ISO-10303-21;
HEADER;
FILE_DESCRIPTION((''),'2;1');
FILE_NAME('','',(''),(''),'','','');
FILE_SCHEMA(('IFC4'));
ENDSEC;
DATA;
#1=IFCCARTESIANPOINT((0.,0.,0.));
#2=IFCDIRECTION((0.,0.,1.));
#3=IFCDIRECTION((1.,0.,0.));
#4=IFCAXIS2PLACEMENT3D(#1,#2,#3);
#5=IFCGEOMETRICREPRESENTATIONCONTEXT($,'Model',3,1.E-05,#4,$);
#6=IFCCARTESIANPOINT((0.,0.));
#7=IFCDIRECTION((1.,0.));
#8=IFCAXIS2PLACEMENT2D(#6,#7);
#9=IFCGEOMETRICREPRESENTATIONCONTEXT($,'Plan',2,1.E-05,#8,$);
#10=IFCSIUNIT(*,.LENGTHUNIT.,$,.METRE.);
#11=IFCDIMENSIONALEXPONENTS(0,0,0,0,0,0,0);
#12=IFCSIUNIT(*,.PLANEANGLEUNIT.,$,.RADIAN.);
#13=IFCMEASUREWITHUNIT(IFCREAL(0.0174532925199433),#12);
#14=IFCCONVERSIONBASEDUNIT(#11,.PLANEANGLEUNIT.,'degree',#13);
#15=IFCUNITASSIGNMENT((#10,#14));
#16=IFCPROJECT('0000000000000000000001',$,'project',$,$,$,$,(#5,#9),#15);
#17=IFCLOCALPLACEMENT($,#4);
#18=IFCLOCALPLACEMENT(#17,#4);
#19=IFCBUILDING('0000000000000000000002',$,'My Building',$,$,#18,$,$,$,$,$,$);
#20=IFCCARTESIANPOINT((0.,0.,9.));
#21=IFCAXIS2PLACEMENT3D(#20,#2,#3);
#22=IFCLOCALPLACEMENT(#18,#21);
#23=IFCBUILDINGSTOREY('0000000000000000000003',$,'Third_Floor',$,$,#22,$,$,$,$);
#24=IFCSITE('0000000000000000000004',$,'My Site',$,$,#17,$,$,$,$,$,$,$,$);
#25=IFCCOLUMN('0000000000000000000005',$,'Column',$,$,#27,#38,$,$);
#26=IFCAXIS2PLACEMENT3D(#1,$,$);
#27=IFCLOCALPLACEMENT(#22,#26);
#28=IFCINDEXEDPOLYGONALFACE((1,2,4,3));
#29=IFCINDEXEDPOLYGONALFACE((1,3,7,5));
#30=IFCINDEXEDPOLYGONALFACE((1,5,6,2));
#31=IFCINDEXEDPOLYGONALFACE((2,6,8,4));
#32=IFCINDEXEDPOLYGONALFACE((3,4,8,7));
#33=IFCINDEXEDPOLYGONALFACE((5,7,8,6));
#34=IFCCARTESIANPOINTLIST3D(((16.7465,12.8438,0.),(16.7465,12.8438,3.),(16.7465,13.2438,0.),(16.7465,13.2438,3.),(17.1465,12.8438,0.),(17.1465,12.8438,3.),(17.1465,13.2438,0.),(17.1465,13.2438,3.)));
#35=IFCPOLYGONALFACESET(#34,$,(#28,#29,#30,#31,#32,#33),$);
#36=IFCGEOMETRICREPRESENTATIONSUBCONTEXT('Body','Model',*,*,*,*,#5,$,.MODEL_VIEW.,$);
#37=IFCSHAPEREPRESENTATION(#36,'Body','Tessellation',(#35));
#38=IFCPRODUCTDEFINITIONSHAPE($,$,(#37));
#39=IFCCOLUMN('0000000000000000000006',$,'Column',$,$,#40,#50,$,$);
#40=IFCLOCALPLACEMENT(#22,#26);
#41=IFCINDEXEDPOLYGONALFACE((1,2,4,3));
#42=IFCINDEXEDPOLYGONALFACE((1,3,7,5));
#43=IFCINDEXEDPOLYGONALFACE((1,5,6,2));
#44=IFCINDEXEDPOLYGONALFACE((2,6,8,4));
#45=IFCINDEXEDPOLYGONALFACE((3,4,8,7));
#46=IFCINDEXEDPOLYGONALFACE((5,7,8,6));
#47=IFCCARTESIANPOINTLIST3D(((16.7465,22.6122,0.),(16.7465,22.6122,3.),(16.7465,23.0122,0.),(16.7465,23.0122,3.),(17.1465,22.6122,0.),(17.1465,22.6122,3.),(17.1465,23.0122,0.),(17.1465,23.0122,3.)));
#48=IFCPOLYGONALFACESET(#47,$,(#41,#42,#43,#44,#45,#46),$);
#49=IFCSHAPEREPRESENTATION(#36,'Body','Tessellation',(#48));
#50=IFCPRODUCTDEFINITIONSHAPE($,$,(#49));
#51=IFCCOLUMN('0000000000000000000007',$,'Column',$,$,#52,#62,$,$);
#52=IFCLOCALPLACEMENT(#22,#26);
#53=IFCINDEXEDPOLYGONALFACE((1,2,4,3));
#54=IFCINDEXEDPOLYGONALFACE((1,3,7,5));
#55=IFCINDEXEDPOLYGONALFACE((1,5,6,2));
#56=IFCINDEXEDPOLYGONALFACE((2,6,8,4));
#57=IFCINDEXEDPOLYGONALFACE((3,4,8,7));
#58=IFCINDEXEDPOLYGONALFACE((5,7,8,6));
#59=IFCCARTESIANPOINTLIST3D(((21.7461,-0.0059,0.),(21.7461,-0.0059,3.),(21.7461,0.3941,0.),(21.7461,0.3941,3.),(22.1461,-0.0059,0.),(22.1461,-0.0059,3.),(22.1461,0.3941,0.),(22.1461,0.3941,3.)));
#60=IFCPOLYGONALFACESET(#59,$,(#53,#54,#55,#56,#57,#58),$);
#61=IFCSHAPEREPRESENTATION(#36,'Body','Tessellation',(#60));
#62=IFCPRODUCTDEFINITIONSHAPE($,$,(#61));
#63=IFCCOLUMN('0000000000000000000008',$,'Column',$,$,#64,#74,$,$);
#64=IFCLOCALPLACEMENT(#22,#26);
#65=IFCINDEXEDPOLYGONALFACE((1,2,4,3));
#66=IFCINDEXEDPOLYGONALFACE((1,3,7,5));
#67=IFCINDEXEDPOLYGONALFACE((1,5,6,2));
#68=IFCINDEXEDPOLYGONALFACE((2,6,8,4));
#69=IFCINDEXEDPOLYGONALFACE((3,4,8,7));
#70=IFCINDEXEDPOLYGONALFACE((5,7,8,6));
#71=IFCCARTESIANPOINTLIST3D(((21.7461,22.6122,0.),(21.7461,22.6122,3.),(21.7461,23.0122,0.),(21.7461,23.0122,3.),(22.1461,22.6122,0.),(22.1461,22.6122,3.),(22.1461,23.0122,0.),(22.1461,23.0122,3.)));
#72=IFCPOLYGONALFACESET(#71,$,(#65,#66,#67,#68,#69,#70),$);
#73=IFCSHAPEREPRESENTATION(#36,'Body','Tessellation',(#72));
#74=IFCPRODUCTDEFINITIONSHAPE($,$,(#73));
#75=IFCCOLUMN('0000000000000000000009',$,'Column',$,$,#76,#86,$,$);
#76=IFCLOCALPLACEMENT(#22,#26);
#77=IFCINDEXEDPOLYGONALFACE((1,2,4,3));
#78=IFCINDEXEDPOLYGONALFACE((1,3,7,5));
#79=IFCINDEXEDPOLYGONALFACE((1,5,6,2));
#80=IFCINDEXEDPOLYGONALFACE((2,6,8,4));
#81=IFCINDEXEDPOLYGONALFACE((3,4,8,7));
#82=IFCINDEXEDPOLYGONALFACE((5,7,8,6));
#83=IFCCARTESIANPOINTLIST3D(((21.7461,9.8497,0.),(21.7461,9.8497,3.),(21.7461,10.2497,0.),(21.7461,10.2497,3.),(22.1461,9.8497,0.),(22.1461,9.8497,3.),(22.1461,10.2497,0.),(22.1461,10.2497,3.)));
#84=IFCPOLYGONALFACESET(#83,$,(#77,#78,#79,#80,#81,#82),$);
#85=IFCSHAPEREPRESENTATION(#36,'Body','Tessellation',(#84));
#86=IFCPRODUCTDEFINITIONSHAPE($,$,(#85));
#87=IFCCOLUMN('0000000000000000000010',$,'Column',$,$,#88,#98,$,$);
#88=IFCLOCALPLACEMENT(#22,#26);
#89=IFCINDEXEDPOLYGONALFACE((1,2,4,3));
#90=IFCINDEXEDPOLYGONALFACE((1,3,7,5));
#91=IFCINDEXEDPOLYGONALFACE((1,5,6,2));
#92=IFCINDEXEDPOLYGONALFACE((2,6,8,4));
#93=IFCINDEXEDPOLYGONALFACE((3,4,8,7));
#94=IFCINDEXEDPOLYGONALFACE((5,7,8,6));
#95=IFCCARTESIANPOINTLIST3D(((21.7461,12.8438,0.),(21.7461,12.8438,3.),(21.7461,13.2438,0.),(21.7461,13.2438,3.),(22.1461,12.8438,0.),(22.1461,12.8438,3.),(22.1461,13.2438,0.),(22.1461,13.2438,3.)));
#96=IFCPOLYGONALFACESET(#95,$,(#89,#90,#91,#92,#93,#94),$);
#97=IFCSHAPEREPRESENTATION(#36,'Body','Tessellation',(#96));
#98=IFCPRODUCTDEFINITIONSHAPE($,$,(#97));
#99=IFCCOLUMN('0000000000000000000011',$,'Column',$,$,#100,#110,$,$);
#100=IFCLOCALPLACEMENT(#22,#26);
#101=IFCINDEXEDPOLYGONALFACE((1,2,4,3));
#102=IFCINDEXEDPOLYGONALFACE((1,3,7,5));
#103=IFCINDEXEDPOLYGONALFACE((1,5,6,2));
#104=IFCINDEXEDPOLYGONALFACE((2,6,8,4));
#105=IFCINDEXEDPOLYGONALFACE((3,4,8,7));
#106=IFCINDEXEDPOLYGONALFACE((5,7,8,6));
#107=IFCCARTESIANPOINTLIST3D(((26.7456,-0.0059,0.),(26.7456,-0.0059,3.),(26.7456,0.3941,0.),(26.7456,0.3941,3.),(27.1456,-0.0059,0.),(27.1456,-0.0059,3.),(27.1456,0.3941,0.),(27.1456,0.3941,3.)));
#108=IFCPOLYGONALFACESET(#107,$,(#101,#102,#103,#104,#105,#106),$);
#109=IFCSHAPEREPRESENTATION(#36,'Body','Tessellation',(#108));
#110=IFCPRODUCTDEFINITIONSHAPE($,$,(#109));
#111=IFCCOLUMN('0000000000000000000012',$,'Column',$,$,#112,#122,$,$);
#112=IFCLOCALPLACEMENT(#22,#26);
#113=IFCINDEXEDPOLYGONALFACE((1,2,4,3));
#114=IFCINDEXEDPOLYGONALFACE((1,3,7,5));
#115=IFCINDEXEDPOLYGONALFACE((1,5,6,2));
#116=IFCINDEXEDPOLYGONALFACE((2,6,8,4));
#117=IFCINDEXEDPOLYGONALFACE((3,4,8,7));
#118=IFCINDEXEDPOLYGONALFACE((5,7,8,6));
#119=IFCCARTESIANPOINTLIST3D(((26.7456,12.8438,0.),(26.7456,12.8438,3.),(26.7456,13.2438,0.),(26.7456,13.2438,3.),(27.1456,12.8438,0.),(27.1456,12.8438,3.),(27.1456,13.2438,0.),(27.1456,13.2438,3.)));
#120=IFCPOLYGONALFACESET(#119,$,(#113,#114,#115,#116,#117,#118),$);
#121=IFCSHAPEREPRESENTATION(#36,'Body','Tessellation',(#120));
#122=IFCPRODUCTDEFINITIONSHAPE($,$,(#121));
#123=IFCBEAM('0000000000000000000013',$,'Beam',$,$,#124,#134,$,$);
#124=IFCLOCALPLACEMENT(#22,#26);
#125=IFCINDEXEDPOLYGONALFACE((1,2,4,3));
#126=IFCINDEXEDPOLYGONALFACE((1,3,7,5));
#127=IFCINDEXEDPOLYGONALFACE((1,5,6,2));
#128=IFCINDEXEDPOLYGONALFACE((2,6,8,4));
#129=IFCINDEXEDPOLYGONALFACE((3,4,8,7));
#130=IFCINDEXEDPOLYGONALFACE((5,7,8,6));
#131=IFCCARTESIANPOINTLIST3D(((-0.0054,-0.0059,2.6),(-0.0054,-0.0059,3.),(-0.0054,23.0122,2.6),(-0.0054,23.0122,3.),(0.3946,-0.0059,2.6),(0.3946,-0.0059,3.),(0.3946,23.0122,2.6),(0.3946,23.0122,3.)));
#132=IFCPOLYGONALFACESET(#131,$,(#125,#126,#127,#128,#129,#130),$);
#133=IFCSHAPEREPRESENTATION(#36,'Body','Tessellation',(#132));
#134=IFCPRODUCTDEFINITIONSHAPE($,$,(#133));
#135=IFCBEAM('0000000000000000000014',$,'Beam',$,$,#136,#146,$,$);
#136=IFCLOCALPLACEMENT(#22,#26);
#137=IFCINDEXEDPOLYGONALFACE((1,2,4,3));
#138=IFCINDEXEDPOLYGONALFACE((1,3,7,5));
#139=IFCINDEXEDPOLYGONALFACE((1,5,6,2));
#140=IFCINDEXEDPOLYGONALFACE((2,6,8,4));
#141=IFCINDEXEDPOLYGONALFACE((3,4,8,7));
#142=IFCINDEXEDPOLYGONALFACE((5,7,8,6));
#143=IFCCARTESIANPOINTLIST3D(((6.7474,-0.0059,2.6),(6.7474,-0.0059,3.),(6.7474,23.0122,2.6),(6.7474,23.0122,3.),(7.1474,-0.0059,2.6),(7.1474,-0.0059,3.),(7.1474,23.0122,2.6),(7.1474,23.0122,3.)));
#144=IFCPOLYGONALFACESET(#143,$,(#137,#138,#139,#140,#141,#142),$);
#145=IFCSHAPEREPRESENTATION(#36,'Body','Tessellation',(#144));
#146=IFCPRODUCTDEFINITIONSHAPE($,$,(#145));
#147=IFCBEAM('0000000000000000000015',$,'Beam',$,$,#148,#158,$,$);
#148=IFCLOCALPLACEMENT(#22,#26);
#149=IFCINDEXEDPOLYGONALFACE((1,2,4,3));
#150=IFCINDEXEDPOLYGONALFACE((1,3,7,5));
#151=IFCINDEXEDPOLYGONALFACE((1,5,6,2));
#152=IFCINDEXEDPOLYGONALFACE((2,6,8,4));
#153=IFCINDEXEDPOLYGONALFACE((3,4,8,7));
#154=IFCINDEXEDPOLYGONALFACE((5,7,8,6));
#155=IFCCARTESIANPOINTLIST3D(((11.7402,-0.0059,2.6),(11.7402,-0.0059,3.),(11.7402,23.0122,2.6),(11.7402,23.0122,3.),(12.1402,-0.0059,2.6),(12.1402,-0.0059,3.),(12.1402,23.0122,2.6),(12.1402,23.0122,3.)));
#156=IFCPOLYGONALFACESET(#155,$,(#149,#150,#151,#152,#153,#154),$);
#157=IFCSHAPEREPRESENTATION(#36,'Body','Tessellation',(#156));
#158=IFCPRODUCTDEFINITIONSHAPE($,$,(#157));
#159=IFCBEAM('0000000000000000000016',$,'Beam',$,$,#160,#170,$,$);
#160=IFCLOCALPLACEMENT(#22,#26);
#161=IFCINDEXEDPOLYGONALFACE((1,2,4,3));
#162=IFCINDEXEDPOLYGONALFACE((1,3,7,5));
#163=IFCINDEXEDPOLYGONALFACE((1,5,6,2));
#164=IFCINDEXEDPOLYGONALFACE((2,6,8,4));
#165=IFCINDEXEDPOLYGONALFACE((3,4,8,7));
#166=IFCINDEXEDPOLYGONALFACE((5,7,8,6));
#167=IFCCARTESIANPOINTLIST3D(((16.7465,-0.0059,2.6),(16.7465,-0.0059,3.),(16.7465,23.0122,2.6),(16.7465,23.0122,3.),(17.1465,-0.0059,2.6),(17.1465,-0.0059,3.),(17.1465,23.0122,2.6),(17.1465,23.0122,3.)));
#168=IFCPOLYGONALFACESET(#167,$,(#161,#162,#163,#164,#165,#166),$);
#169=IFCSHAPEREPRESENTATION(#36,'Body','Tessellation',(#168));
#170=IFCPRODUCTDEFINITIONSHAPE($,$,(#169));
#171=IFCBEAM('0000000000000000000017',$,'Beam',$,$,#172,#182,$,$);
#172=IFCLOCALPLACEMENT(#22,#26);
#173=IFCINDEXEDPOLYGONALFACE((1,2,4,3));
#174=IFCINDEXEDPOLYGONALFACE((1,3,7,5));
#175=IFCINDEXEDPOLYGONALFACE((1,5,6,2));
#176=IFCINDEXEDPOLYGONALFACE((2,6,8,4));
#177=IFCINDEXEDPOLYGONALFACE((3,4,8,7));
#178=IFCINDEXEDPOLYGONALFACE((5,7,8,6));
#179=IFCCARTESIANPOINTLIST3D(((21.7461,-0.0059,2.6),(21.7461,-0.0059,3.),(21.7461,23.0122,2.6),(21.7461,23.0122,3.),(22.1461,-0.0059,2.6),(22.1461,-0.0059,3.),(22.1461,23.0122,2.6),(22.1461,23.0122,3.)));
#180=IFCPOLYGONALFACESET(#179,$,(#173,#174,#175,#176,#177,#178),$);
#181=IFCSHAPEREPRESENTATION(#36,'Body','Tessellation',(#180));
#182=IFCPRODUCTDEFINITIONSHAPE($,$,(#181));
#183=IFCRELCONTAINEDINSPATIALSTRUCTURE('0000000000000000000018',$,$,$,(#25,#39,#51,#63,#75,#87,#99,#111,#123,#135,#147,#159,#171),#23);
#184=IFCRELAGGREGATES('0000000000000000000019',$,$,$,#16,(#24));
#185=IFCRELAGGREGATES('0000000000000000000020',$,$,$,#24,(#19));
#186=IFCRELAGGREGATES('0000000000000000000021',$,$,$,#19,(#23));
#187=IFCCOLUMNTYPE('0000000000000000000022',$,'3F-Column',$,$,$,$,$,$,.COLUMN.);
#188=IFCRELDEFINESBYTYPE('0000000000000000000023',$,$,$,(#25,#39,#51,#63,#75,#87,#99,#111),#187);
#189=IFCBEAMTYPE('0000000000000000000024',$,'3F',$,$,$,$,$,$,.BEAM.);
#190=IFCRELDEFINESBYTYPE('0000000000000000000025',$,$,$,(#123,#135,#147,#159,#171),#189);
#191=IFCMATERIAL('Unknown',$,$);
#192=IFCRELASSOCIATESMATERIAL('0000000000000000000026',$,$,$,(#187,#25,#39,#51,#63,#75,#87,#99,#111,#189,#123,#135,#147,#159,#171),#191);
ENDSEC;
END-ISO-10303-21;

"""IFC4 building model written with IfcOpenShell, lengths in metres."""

from ifc_helpers import new_model, entity, si_unit, converted_unit, frame, origin_with_axes, origin_2d_with_axis, place, context, subcontext, project, spatial, rectangle, extrude, material, material_profile, profile_set, profile_usage, type_object, element, save


model = new_model("IFC4")

# Units and contexts
model_context = context("Model", 3, precision=1e-05, world=origin_with_axes())
plan_context = context("Plan", 2, precision=1e-05, world=origin_2d_with_axis())
body_context = subcontext(model_context, "Body", "Model", "MODEL_VIEW")
ifc_project = project(units=[si_unit("LENGTHUNIT", "METRE"), converted_unit("PLANEANGLEUNIT", "degree", entity("IfcReal", 0.0174532925199433), si_unit("PLANEANGLEUNIT", "RADIAN"), dimensions=[0, 0, 0, 0, 0, 0, 0])], contexts=[model_context, plan_context])

# Site, building, storey
site_placement = place(None, origin_with_axes())
site = spatial("IfcSite", under=ifc_project, at=site_placement, Name="My Site")
building_placement = place(site_placement, origin_with_axes())
building = spatial("IfcBuilding", under=site, at=building_placement, Name="My Building")
storey_placement = place(building_placement, frame((0.0, 0.0, 9.0), z_axis=(0.0, 0.0, 1.0), x_axis=(1.0, 0.0, 0.0)))
storey = spatial("IfcBuildingStorey", under=building, at=storey_placement, Name="Third_Floor")

# Columns
ifc_material = material(Name="Unknown")
ifc_material_profile_1 = material_profile(ifc_material, rectangle(XDim=0.4, YDim=0.4))
ifc_profile_set_1 = profile_set([ifc_material_profile_1])
column_type = type_object("IfcColumnType", Name="3F-Column", PredefinedType="COLUMN", material=ifc_profile_set_1)
ifc_profile_usage_1 = profile_usage(ifc_profile_set_1, cardinal=8)
column_1_placement = place(storey_placement, frame((16.9465, 13.2438, 0.0), z_axis=(0.0, 0.0, 1.0), x_axis=(1.0, 0.0, 0.0)))
element("IfcColumn", 1, at=column_1_placement, inside=storey, type_object=column_type, material=ifc_profile_usage_1, Name="Column", context=body_context, shape_type="SweptSolid", body=[
    extrude(rectangle(XDim=0.4, YDim=0.4), frame((0.0, -0.2, 0.0), z_axis=(0.0, 0.0, 1.0), x_axis=(1.0, 0.0, 0.0)), (0.0, 0.0, 1.0), 3.0),
])
ifc_profile_usage_2 = profile_usage(ifc_profile_set_1, cardinal=8)
column_2_placement = place(storey_placement, frame((16.9465, 23.0122, 0.0), z_axis=(0.0, 0.0, 1.0), x_axis=(1.0, 0.0, 0.0)))
element("IfcColumn", 2, at=column_2_placement, inside=storey, type_object=column_type, material=ifc_profile_usage_2, Name="Column", context=body_context, shape_type="SweptSolid", body=[
    extrude(rectangle(XDim=0.4, YDim=0.4), frame((0.0, -0.2, 0.0), z_axis=(0.0, 0.0, 1.0), x_axis=(1.0, 0.0, 0.0)), (0.0, 0.0, 1.0), 3.0),
])
ifc_profile_usage_3 = profile_usage(ifc_profile_set_1, cardinal=8)
column_3_placement = place(storey_placement, frame((21.9461, 0.3941, 0.0), z_axis=(0.0, 0.0, 1.0), x_axis=(1.0, 0.0, 0.0)))
element("IfcColumn", 3, at=column_3_placement, inside=storey, type_object=column_type, material=ifc_profile_usage_3, Name="Column", context=body_context, shape_type="SweptSolid", body=[
    extrude(rectangle(XDim=0.4, YDim=0.4), frame((0.0, -0.2, 0.0), z_axis=(0.0, 0.0, 1.0), x_axis=(1.0, 0.0, 0.0)), (0.0, 0.0, 1.0), 3.0),
])
ifc_profile_usage_4 = profile_usage(ifc_profile_set_1, cardinal=8)
column_4_placement = place(storey_placement, frame((21.9461, 23.0122, 0.0), z_axis=(0.0, 0.0, 1.0), x_axis=(1.0, 0.0, 0.0)))
element("IfcColumn", 4, at=column_4_placement, inside=storey, type_object=column_type, material=ifc_profile_usage_4, Name="Column", context=body_context, shape_type="SweptSolid", body=[
    extrude(rectangle(XDim=0.4, YDim=0.4), frame((0.0, -0.2, 0.0), z_axis=(0.0, 0.0, 1.0), x_axis=(1.0, 0.0, 0.0)), (0.0, 0.0, 1.0), 3.0),
])
ifc_profile_usage_5 = profile_usage(ifc_profile_set_1, cardinal=8)
column_5_placement = place(storey_placement, frame((21.9461, 10.2497, 0.0), z_axis=(0.0, 0.0, 1.0), x_axis=(1.0, 0.0, 0.0)))
element("IfcColumn", 5, at=column_5_placement, inside=storey, type_object=column_type, material=ifc_profile_usage_5, Name="Column", context=body_context, shape_type="SweptSolid", body=[
    extrude(rectangle(XDim=0.4, YDim=0.4), frame((0.0, -0.2, 0.0), z_axis=(0.0, 0.0, 1.0), x_axis=(1.0, 0.0, 0.0)), (0.0, 0.0, 1.0), 3.0),
])
ifc_profile_usage_6 = profile_usage(ifc_profile_set_1, cardinal=8)
column_6_placement = place(storey_placement, frame((21.9461, 13.2438, 0.0), z_axis=(0.0, 0.0, 1.0), x_axis=(1.0, 0.0, 0.0)))
element("IfcColumn", 6, at=column_6_placement, inside=storey, type_object=column_type, material=ifc_profile_usage_6, Name="Column", context=body_context, shape_type="SweptSolid", body=[
    extrude(rectangle(XDim=0.4, YDim=0.4), frame((0.0, -0.2, 0.0), z_axis=(0.0, 0.0, 1.0), x_axis=(1.0, 0.0, 0.0)), (0.0, 0.0, 1.0), 3.0),
])
ifc_profile_usage_7 = profile_usage(ifc_profile_set_1, cardinal=8)
column_7_placement = place(storey_placement, frame((26.9456, 0.3941, 0.0), z_axis=(0.0, 0.0, 1.0), x_axis=(1.0, 0.0, 0.0)))
element("IfcColumn", 7, at=column_7_placement, inside=storey, type_object=column_type, material=ifc_profile_usage_7, Name="Column", context=body_context, shape_type="SweptSolid", body=[
    extrude(rectangle(XDim=0.4, YDim=0.4), frame((0.0, -0.2, 0.0), z_axis=(0.0, 0.0, 1.0), x_axis=(1.0, 0.0, 0.0)), (0.0, 0.0, 1.0), 3.0),
])
ifc_profile_usage_8 = profile_usage(ifc_profile_set_1, cardinal=8)
column_8_placement = place(storey_placement, frame((26.9456, 13.2438, 0.0), z_axis=(0.0, 0.0, 1.0), x_axis=(1.0, 0.0, 0.0)))
element("IfcColumn", 8, at=column_8_placement, inside=storey, type_object=column_type, material=ifc_profile_usage_8, Name="Column", context=body_context, shape_type="SweptSolid", body=[
    extrude(rectangle(XDim=0.4, YDim=0.4), frame((0.0, -0.2, 0.0), z_axis=(0.0, 0.0, 1.0), x_axis=(1.0, 0.0, 0.0)), (0.0, 0.0, 1.0), 3.0),
])

# Beams
ifc_material_profile_2 = material_profile(ifc_material, rectangle(XDim=0.4, YDim=0.4))
ifc_profile_set_2 = profile_set([ifc_material_profile_2])
ifc_profile_usage_9 = profile_usage(ifc_profile_set_2, cardinal=8)
beam_type = type_object("IfcBeamType", Name="3F", PredefinedType="BEAM", material=ifc_profile_set_2)
beam_1_placement = place(storey_placement, frame((0.1946, 23.0122, 3.0), z_axis=(0.0, -1.0, 0.0), x_axis=(1.0, 0.0, 0.0)))
element("IfcBeam", 9, at=beam_1_placement, inside=storey, type_object=beam_type, material=ifc_profile_usage_9, Name="Beam", context=body_context, shape_type="SweptSolid", body=[
    extrude(rectangle(XDim=0.4, YDim=0.4), frame((0.0, -0.2, 0.0), z_axis=(0.0, 0.0, 1.0), x_axis=(1.0, 0.0, 0.0)), (0.0, 0.0, 1.0), 23.0181),
])
ifc_profile_usage_10 = profile_usage(ifc_profile_set_2, cardinal=8)
beam_2_placement = place(storey_placement, frame((6.9474, 23.0122, 3.0), z_axis=(0.0, -1.0, 0.0), x_axis=(1.0, 0.0, 0.0)))
element("IfcBeam", 10, at=beam_2_placement, inside=storey, type_object=beam_type, material=ifc_profile_usage_10, Name="Beam", context=body_context, shape_type="SweptSolid", body=[
    extrude(rectangle(XDim=0.4, YDim=0.4), frame((0.0, -0.2, 0.0), z_axis=(0.0, 0.0, 1.0), x_axis=(1.0, 0.0, 0.0)), (0.0, 0.0, 1.0), 23.0181),
])
ifc_profile_usage_11 = profile_usage(ifc_profile_set_2, cardinal=8)
beam_3_placement = place(storey_placement, frame((11.9402, 23.0122, 3.0), z_axis=(0.0, -1.0, 0.0), x_axis=(1.0, 0.0, 0.0)))
element("IfcBeam", 11, at=beam_3_placement, inside=storey, type_object=beam_type, material=ifc_profile_usage_11, Name="Beam", context=body_context, shape_type="SweptSolid", body=[
    extrude(rectangle(XDim=0.4, YDim=0.4), frame((0.0, -0.2, 0.0), z_axis=(0.0, 0.0, 1.0), x_axis=(1.0, 0.0, 0.0)), (0.0, 0.0, 1.0), 23.0181),
])
ifc_profile_usage_12 = profile_usage(ifc_profile_set_2, cardinal=8)
beam_4_placement = place(storey_placement, frame((16.9465, 23.0122, 3.0), z_axis=(0.0, -1.0, 0.0), x_axis=(1.0, 0.0, 0.0)))
element("IfcBeam", 12, at=beam_4_placement, inside=storey, type_object=beam_type, material=ifc_profile_usage_12, Name="Beam", context=body_context, shape_type="SweptSolid", body=[
    extrude(rectangle(XDim=0.4, YDim=0.4), frame((0.0, -0.2, 0.0), z_axis=(0.0, 0.0, 1.0), x_axis=(1.0, 0.0, 0.0)), (0.0, 0.0, 1.0), 23.0181),
])
ifc_profile_usage_13 = profile_usage(ifc_profile_set_2, cardinal=8)
beam_5_placement = place(storey_placement, frame((21.9461, 23.0122, 3.0), z_axis=(0.0, -1.0, 0.0), x_axis=(1.0, 0.0, 0.0)))
element("IfcBeam", 13, at=beam_5_placement, inside=storey, type_object=beam_type, material=ifc_profile_usage_13, Name="Beam", context=body_context, shape_type="SweptSolid", body=[
    extrude(rectangle(XDim=0.4, YDim=0.4), frame((0.0, -0.2, 0.0), z_axis=(0.0, 0.0, 1.0), x_axis=(1.0, 0.0, 0.0)), (0.0, 0.0, 1.0), 23.0181),
])

save(model, "model.ifc")
